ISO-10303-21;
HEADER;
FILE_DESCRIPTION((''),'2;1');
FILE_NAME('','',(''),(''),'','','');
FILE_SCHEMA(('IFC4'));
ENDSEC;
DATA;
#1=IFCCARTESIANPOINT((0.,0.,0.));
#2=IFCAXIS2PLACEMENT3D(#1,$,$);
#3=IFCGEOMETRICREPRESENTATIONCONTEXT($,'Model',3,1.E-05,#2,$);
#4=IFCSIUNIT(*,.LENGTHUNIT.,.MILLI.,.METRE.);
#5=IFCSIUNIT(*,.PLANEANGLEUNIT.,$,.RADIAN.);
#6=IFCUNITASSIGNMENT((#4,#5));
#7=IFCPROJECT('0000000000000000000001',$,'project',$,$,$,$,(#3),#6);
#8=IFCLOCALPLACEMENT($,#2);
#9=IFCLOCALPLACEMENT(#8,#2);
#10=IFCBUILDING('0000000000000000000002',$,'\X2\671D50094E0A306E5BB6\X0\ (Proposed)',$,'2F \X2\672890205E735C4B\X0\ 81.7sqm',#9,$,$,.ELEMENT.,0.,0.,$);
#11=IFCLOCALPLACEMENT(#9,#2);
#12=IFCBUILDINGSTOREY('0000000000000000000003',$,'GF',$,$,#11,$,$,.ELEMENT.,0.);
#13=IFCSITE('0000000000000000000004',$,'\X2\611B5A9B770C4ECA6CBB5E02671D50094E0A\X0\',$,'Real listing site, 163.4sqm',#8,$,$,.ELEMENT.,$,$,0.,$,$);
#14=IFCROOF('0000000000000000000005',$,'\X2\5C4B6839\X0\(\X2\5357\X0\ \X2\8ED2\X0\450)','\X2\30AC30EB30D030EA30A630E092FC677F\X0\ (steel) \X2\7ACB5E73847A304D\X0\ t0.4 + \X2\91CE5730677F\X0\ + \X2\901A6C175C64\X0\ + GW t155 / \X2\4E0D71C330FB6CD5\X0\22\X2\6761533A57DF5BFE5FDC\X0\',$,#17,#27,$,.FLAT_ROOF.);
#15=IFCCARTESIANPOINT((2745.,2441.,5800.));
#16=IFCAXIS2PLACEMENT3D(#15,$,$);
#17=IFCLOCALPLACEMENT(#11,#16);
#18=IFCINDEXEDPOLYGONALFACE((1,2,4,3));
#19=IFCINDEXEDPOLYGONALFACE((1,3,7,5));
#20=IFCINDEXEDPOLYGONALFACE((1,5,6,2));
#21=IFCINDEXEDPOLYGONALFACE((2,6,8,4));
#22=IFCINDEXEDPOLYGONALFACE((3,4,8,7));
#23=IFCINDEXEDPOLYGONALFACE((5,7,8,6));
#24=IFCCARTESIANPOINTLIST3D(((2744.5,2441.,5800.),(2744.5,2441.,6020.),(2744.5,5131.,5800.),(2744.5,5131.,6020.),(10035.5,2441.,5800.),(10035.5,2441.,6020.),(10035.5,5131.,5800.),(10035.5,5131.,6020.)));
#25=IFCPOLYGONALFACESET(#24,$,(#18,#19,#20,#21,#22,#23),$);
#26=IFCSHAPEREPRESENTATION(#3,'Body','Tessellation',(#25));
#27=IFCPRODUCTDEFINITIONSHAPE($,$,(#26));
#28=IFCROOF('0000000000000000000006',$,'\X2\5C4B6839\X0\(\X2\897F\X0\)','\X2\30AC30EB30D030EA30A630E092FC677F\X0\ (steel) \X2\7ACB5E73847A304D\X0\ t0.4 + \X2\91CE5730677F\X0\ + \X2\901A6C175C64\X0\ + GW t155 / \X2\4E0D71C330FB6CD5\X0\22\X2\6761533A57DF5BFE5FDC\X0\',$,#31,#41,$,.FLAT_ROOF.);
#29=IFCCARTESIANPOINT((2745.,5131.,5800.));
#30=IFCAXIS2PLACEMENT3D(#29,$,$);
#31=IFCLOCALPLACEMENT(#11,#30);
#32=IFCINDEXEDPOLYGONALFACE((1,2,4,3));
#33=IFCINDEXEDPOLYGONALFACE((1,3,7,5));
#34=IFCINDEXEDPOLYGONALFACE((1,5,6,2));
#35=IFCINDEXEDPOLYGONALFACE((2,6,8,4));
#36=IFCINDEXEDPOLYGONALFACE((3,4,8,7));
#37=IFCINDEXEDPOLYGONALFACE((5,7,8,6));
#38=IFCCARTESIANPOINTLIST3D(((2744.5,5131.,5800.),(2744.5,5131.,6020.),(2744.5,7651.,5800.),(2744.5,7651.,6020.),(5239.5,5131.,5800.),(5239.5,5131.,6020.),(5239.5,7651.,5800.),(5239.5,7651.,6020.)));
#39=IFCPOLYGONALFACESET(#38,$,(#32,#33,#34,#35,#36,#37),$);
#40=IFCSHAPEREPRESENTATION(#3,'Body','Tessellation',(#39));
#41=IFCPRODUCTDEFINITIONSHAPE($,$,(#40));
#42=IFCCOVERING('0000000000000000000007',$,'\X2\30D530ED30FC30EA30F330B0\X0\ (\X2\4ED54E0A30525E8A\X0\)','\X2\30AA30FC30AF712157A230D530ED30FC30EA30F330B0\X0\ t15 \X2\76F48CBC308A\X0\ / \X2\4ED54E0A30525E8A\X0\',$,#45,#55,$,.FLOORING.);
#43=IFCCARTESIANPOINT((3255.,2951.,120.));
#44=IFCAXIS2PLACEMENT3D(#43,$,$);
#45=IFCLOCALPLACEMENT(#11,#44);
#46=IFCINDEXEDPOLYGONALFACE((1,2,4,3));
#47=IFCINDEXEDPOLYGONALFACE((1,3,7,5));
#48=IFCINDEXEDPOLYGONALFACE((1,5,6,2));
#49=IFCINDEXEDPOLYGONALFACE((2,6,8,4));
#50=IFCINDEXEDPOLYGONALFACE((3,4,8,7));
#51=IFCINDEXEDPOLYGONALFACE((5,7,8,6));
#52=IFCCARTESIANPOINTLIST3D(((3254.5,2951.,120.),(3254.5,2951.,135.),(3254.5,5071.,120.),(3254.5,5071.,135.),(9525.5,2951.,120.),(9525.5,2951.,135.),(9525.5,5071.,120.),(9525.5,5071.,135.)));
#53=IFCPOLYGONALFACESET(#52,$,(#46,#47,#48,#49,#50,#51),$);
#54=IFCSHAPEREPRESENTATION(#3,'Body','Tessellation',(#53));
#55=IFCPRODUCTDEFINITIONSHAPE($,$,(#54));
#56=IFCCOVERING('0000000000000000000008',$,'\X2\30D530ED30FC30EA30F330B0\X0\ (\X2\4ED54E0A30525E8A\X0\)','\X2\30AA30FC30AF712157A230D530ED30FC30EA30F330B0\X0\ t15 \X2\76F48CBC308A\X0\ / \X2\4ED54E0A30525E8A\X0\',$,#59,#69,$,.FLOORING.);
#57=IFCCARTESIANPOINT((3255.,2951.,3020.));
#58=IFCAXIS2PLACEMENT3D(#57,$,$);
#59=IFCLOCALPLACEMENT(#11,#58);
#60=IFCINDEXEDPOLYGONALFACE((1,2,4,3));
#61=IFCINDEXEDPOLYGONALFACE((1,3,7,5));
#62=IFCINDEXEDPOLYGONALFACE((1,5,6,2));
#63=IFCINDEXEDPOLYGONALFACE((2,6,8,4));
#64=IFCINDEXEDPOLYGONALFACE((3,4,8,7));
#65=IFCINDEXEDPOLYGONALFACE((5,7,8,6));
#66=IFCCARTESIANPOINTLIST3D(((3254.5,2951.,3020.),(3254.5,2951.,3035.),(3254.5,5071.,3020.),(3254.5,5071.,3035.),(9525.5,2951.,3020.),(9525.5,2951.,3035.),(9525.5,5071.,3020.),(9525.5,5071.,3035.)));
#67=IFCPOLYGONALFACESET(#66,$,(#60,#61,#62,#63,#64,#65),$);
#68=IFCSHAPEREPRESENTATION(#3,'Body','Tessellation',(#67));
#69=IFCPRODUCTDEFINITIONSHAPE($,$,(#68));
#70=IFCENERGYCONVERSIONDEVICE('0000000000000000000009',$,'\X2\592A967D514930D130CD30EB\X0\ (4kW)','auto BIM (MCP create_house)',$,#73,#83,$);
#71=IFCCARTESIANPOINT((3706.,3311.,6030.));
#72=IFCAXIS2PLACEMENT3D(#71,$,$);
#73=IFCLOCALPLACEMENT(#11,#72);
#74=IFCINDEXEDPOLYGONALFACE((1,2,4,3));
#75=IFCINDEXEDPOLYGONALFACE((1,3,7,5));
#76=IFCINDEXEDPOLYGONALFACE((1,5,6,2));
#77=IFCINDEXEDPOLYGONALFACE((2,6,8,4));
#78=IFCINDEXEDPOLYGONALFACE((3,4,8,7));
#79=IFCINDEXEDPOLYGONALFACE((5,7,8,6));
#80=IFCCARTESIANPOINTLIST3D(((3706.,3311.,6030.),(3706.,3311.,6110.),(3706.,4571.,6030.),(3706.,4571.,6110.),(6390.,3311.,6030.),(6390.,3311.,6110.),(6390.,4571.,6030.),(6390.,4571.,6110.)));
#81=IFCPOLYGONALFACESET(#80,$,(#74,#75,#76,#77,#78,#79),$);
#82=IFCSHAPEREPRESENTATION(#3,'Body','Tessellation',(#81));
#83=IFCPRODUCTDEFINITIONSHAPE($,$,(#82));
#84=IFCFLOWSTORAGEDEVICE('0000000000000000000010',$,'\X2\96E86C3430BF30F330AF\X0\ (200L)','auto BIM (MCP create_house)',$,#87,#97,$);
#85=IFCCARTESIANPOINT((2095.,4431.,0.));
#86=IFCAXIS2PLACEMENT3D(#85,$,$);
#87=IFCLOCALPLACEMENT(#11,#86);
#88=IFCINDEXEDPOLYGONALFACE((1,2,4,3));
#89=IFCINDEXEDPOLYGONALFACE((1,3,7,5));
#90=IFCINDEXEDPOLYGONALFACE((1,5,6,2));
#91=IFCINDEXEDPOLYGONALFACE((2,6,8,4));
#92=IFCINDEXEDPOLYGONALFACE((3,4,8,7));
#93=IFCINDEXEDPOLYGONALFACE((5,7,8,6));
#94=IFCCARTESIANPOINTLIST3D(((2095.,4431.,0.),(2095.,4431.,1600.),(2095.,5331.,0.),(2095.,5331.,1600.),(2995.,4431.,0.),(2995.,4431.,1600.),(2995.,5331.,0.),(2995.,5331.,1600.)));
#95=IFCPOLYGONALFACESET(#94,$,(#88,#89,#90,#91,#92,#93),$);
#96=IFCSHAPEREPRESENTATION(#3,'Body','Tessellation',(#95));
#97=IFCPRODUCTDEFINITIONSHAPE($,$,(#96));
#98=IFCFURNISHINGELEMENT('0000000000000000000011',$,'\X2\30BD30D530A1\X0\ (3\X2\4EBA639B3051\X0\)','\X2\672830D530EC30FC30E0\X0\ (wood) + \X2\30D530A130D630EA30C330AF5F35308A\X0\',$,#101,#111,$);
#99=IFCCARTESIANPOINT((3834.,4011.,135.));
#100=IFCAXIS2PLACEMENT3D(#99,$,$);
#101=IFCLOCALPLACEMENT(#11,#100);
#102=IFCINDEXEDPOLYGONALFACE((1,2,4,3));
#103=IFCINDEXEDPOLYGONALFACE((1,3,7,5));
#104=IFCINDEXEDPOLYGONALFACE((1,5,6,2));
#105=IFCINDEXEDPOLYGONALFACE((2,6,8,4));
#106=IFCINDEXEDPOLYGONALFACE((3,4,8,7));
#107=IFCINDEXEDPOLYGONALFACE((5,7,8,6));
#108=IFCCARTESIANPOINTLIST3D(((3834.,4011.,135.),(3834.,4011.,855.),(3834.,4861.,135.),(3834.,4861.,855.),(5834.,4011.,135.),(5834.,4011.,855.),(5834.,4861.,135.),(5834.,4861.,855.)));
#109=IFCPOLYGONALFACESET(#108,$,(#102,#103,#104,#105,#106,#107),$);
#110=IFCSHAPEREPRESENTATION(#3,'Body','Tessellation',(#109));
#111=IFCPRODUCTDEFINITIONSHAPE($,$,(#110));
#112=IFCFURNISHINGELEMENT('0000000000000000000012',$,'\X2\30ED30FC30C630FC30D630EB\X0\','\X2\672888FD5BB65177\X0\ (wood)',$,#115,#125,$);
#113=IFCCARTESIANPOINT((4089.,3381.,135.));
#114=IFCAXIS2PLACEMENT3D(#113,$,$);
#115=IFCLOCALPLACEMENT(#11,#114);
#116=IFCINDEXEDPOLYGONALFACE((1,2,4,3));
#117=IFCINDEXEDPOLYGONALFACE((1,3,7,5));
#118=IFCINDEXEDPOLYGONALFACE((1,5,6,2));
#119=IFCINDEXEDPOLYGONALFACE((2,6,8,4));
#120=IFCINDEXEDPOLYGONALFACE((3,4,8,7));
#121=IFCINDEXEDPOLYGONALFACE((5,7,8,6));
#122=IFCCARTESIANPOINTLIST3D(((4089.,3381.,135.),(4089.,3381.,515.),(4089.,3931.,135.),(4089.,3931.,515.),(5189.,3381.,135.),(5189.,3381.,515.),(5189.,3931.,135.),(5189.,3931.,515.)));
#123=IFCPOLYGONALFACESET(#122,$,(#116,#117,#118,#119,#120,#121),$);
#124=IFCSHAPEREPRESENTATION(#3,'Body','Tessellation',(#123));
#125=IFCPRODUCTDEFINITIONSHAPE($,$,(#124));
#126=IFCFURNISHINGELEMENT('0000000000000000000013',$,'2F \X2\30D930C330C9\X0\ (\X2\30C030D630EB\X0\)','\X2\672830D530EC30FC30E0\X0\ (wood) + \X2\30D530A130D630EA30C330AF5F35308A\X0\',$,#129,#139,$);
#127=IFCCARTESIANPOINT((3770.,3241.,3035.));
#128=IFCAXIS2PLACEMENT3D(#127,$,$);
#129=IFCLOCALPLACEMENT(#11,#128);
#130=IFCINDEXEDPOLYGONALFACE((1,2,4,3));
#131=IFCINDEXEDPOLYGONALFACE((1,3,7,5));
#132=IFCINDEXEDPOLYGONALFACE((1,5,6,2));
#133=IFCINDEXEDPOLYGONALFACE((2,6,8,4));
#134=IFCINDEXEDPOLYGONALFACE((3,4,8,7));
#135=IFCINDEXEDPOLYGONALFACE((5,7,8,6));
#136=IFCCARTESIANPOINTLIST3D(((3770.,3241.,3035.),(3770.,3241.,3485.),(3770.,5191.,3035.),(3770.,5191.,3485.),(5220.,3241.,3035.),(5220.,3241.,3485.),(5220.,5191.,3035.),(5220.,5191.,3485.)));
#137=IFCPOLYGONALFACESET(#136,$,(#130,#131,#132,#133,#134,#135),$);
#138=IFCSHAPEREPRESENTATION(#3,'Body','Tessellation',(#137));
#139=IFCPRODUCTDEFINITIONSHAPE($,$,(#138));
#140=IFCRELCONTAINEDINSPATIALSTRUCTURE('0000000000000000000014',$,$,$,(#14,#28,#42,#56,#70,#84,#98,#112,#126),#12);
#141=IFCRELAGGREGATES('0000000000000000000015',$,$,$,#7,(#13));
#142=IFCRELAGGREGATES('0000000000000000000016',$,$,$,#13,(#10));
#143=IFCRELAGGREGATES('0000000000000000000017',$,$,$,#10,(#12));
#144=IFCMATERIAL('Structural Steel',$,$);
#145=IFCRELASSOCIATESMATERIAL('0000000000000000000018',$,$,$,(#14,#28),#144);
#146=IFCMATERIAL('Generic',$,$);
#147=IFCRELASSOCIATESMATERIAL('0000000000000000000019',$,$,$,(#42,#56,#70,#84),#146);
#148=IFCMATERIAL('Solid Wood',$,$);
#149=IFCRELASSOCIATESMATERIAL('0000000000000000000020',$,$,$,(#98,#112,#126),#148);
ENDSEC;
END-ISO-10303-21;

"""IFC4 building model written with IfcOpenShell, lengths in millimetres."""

from ifc_helpers import new_model, si_unit, frame, frame_2d, origin, place, context, project, spatial, rectangle, extrude, material, element, save


model = new_model("IFC4")

# Units and contexts
model_context = context("Model", 3, precision=1e-05, world=origin())
ifc_project = project(units=[si_unit("LENGTHUNIT", "METRE", prefix="MILLI"), si_unit("PLANEANGLEUNIT", "RADIAN")], contexts=[model_context])

# Site, building, storey
site_placement = place(None, origin())
site = spatial("IfcSite", under=ifc_project, at=site_placement, Name="愛媛県今治市朝倉上", ObjectType="Real listing site, 163.4sqm", CompositionType="ELEMENT", RefElevation=0.0)
building_placement = place(site_placement, origin())
building = spatial("IfcBuilding", under=site, at=building_placement, Name="朝倉上の家 (Proposed)", ObjectType="2F 木造平屋 81.7sqm", CompositionType="ELEMENT", ElevationOfRefHeight=0.0, ElevationOfTerrain=0.0)
storey_placement = place(building_placement, origin())
storey = spatial("IfcBuildingStorey", under=building, at=storey_placement, Name="GF", CompositionType="ELEMENT", Elevation=0.0)

# Shared definitions
ifc_material_1 = material(Name="Solid Wood")

# Roofs
ifc_material_2 = material(Name="Structural Steel")
roof_1_placement = place(storey_placement, frame((2745.0, 2441.0, 5800.0)))
element("IfcRoof", 1, at=roof_1_placement, inside=storey, material=ifc_material_2, Name="屋根(南 軒450)", Description="ガルバリウム鋼板 (steel) 立平葺き t0.4 + 野地板 + 通気層 + GW t155 / 不燃・法22条区域対応", PredefinedType="FLAT_ROOF", context=model_context, shape_type="SweptSolid", body=[
    extrude(rectangle(XDim=7291.0, YDim=2690.0, at=frame_2d((3645.0, 1345.0))), frame((2745.0, 2441.0, 5800.0)), (0.0, 0.0, 1.0), 220.0),
])
roof_2_placement = place(storey_placement, frame((2745.0, 5131.0, 5800.0)))
element("IfcRoof", 2, at=roof_2_placement, inside=storey, material=ifc_material_2, Name="屋根(西)", Description="ガルバリウム鋼板 (steel) 立平葺き t0.4 + 野地板 + 通気層 + GW t155 / 不燃・法22条区域対応", PredefinedType="FLAT_ROOF", context=model_context, shape_type="SweptSolid", body=[
    extrude(rectangle(XDim=2495.0, YDim=2520.0, at=frame_2d((1247.0, 1260.0))), frame((2745.0, 5131.0, 5800.0)), (0.0, 0.0, 1.0), 220.0),
])

# Coverings
ifc_material_3 = material(Name="Generic")
covering_1_placement = place(storey_placement, frame((3255.0, 2951.0, 120.0)))
element("IfcCovering", 3, at=covering_1_placement, inside=storey, material=ifc_material_3, Name="フローリング (仕上げ床)", Description="オーク無垢フローリング t15 直貼り / 仕上げ床", PredefinedType="FLOORING", context=model_context, shape_type="SweptSolid", body=[
    extrude(rectangle(XDim=6271.0, YDim=2120.0, at=frame_2d((3135.0, 1060.0))), frame((3255.0, 2951.0, 120.0)), (0.0, 0.0, 1.0), 15.0),
])
covering_2_placement = place(storey_placement, frame((3255.0, 2951.0, 3020.0)))
element("IfcCovering", 4, at=covering_2_placement, inside=storey, material=ifc_material_3, Name="フローリング (仕上げ床)", Description="オーク無垢フローリング t15 直貼り / 仕上げ床", PredefinedType="FLOORING", context=model_context, shape_type="SweptSolid", body=[
    extrude(rectangle(XDim=6271.0, YDim=2120.0, at=frame_2d((3135.0, 1060.0))), frame((3255.0, 2951.0, 3020.0)), (0.0, 0.0, 1.0), 15.0),
])

# Energy conversion device
energy_conversion_device_placement = place(storey_placement, frame((3706.0, 3311.0, 6030.0)))
element("IfcEnergyConversionDevice", 5, at=energy_conversion_device_placement, inside=storey, material=ifc_material_3, Name="太陽光パネル (4kW)", Description="auto BIM (MCP create_house)", context=model_context, shape_type="SweptSolid", body=[
    extrude(rectangle(XDim=2684.0, YDim=1260.0, at=frame_2d((1342.0, 630.0))), frame((3706.0, 3311.0, 6030.0)), (0.0, 0.0, 1.0), 80.0),
])

# Flow storage device
flow_storage_device_placement = place(storey_placement, frame((2095.0, 4431.0, 0.0)))
element("IfcFlowStorageDevice", 6, at=flow_storage_device_placement, inside=storey, material=ifc_material_3, Name="雨水タンク (200L)", Description="auto BIM (MCP create_house)", context=model_context, shape_type="SweptSolid", body=[
    extrude(rectangle(XDim=900.0, YDim=900.0, at=frame_2d((450.0, 450.0))), frame((2095.0, 4431.0, 0.0)), (0.0, 0.0, 1.0), 1600.0),
])

# Furnishing elements
furnishing_1_placement = place(storey_placement, frame((3834.0, 4011.0, 135.0)))
element("IfcFurnishingElement", 7, at=furnishing_1_placement, inside=storey, material=ifc_material_1, Name="ソファ (3人掛け)", Description="木フレーム (wood) + ファブリック張り", context=model_context, shape_type="SweptSolid", body=[
    extrude(rectangle(XDim=2000.0, YDim=850.0, at=frame_2d((1000.0, 425.0))), frame((3834.0, 4011.0, 135.0)), (0.0, 0.0, 1.0), 720.0),
])
furnishing_2_placement = place(storey_placement, frame((4089.0, 3381.0, 135.0)))
element("IfcFurnishingElement", 8, at=furnishing_2_placement, inside=storey, material=ifc_material_1, Name="ローテーブル", Description="木製家具 (wood)", context=model_context, shape_type="SweptSolid", body=[
    extrude(rectangle(XDim=1100.0, YDim=550.0, at=frame_2d((550.0, 275.0))), frame((4089.0, 3381.0, 135.0)), (0.0, 0.0, 1.0), 380.0),
])
furnishing_3_placement = place(storey_placement, frame((3770.0, 3241.0, 3035.0)))
element("IfcFurnishingElement", 9, at=furnishing_3_placement, inside=storey, material=ifc_material_1, Name="2F ベッド (ダブル)", Description="木フレーム (wood) + ファブリック張り", context=model_context, shape_type="SweptSolid", body=[
    extrude(rectangle(XDim=1450.0, YDim=1950.0, at=frame_2d((725.0, 975.0))), frame((3770.0, 3241.0, 3035.0)), (0.0, 0.0, 1.0), 450.0),
])

save(model, "model.ifc")
